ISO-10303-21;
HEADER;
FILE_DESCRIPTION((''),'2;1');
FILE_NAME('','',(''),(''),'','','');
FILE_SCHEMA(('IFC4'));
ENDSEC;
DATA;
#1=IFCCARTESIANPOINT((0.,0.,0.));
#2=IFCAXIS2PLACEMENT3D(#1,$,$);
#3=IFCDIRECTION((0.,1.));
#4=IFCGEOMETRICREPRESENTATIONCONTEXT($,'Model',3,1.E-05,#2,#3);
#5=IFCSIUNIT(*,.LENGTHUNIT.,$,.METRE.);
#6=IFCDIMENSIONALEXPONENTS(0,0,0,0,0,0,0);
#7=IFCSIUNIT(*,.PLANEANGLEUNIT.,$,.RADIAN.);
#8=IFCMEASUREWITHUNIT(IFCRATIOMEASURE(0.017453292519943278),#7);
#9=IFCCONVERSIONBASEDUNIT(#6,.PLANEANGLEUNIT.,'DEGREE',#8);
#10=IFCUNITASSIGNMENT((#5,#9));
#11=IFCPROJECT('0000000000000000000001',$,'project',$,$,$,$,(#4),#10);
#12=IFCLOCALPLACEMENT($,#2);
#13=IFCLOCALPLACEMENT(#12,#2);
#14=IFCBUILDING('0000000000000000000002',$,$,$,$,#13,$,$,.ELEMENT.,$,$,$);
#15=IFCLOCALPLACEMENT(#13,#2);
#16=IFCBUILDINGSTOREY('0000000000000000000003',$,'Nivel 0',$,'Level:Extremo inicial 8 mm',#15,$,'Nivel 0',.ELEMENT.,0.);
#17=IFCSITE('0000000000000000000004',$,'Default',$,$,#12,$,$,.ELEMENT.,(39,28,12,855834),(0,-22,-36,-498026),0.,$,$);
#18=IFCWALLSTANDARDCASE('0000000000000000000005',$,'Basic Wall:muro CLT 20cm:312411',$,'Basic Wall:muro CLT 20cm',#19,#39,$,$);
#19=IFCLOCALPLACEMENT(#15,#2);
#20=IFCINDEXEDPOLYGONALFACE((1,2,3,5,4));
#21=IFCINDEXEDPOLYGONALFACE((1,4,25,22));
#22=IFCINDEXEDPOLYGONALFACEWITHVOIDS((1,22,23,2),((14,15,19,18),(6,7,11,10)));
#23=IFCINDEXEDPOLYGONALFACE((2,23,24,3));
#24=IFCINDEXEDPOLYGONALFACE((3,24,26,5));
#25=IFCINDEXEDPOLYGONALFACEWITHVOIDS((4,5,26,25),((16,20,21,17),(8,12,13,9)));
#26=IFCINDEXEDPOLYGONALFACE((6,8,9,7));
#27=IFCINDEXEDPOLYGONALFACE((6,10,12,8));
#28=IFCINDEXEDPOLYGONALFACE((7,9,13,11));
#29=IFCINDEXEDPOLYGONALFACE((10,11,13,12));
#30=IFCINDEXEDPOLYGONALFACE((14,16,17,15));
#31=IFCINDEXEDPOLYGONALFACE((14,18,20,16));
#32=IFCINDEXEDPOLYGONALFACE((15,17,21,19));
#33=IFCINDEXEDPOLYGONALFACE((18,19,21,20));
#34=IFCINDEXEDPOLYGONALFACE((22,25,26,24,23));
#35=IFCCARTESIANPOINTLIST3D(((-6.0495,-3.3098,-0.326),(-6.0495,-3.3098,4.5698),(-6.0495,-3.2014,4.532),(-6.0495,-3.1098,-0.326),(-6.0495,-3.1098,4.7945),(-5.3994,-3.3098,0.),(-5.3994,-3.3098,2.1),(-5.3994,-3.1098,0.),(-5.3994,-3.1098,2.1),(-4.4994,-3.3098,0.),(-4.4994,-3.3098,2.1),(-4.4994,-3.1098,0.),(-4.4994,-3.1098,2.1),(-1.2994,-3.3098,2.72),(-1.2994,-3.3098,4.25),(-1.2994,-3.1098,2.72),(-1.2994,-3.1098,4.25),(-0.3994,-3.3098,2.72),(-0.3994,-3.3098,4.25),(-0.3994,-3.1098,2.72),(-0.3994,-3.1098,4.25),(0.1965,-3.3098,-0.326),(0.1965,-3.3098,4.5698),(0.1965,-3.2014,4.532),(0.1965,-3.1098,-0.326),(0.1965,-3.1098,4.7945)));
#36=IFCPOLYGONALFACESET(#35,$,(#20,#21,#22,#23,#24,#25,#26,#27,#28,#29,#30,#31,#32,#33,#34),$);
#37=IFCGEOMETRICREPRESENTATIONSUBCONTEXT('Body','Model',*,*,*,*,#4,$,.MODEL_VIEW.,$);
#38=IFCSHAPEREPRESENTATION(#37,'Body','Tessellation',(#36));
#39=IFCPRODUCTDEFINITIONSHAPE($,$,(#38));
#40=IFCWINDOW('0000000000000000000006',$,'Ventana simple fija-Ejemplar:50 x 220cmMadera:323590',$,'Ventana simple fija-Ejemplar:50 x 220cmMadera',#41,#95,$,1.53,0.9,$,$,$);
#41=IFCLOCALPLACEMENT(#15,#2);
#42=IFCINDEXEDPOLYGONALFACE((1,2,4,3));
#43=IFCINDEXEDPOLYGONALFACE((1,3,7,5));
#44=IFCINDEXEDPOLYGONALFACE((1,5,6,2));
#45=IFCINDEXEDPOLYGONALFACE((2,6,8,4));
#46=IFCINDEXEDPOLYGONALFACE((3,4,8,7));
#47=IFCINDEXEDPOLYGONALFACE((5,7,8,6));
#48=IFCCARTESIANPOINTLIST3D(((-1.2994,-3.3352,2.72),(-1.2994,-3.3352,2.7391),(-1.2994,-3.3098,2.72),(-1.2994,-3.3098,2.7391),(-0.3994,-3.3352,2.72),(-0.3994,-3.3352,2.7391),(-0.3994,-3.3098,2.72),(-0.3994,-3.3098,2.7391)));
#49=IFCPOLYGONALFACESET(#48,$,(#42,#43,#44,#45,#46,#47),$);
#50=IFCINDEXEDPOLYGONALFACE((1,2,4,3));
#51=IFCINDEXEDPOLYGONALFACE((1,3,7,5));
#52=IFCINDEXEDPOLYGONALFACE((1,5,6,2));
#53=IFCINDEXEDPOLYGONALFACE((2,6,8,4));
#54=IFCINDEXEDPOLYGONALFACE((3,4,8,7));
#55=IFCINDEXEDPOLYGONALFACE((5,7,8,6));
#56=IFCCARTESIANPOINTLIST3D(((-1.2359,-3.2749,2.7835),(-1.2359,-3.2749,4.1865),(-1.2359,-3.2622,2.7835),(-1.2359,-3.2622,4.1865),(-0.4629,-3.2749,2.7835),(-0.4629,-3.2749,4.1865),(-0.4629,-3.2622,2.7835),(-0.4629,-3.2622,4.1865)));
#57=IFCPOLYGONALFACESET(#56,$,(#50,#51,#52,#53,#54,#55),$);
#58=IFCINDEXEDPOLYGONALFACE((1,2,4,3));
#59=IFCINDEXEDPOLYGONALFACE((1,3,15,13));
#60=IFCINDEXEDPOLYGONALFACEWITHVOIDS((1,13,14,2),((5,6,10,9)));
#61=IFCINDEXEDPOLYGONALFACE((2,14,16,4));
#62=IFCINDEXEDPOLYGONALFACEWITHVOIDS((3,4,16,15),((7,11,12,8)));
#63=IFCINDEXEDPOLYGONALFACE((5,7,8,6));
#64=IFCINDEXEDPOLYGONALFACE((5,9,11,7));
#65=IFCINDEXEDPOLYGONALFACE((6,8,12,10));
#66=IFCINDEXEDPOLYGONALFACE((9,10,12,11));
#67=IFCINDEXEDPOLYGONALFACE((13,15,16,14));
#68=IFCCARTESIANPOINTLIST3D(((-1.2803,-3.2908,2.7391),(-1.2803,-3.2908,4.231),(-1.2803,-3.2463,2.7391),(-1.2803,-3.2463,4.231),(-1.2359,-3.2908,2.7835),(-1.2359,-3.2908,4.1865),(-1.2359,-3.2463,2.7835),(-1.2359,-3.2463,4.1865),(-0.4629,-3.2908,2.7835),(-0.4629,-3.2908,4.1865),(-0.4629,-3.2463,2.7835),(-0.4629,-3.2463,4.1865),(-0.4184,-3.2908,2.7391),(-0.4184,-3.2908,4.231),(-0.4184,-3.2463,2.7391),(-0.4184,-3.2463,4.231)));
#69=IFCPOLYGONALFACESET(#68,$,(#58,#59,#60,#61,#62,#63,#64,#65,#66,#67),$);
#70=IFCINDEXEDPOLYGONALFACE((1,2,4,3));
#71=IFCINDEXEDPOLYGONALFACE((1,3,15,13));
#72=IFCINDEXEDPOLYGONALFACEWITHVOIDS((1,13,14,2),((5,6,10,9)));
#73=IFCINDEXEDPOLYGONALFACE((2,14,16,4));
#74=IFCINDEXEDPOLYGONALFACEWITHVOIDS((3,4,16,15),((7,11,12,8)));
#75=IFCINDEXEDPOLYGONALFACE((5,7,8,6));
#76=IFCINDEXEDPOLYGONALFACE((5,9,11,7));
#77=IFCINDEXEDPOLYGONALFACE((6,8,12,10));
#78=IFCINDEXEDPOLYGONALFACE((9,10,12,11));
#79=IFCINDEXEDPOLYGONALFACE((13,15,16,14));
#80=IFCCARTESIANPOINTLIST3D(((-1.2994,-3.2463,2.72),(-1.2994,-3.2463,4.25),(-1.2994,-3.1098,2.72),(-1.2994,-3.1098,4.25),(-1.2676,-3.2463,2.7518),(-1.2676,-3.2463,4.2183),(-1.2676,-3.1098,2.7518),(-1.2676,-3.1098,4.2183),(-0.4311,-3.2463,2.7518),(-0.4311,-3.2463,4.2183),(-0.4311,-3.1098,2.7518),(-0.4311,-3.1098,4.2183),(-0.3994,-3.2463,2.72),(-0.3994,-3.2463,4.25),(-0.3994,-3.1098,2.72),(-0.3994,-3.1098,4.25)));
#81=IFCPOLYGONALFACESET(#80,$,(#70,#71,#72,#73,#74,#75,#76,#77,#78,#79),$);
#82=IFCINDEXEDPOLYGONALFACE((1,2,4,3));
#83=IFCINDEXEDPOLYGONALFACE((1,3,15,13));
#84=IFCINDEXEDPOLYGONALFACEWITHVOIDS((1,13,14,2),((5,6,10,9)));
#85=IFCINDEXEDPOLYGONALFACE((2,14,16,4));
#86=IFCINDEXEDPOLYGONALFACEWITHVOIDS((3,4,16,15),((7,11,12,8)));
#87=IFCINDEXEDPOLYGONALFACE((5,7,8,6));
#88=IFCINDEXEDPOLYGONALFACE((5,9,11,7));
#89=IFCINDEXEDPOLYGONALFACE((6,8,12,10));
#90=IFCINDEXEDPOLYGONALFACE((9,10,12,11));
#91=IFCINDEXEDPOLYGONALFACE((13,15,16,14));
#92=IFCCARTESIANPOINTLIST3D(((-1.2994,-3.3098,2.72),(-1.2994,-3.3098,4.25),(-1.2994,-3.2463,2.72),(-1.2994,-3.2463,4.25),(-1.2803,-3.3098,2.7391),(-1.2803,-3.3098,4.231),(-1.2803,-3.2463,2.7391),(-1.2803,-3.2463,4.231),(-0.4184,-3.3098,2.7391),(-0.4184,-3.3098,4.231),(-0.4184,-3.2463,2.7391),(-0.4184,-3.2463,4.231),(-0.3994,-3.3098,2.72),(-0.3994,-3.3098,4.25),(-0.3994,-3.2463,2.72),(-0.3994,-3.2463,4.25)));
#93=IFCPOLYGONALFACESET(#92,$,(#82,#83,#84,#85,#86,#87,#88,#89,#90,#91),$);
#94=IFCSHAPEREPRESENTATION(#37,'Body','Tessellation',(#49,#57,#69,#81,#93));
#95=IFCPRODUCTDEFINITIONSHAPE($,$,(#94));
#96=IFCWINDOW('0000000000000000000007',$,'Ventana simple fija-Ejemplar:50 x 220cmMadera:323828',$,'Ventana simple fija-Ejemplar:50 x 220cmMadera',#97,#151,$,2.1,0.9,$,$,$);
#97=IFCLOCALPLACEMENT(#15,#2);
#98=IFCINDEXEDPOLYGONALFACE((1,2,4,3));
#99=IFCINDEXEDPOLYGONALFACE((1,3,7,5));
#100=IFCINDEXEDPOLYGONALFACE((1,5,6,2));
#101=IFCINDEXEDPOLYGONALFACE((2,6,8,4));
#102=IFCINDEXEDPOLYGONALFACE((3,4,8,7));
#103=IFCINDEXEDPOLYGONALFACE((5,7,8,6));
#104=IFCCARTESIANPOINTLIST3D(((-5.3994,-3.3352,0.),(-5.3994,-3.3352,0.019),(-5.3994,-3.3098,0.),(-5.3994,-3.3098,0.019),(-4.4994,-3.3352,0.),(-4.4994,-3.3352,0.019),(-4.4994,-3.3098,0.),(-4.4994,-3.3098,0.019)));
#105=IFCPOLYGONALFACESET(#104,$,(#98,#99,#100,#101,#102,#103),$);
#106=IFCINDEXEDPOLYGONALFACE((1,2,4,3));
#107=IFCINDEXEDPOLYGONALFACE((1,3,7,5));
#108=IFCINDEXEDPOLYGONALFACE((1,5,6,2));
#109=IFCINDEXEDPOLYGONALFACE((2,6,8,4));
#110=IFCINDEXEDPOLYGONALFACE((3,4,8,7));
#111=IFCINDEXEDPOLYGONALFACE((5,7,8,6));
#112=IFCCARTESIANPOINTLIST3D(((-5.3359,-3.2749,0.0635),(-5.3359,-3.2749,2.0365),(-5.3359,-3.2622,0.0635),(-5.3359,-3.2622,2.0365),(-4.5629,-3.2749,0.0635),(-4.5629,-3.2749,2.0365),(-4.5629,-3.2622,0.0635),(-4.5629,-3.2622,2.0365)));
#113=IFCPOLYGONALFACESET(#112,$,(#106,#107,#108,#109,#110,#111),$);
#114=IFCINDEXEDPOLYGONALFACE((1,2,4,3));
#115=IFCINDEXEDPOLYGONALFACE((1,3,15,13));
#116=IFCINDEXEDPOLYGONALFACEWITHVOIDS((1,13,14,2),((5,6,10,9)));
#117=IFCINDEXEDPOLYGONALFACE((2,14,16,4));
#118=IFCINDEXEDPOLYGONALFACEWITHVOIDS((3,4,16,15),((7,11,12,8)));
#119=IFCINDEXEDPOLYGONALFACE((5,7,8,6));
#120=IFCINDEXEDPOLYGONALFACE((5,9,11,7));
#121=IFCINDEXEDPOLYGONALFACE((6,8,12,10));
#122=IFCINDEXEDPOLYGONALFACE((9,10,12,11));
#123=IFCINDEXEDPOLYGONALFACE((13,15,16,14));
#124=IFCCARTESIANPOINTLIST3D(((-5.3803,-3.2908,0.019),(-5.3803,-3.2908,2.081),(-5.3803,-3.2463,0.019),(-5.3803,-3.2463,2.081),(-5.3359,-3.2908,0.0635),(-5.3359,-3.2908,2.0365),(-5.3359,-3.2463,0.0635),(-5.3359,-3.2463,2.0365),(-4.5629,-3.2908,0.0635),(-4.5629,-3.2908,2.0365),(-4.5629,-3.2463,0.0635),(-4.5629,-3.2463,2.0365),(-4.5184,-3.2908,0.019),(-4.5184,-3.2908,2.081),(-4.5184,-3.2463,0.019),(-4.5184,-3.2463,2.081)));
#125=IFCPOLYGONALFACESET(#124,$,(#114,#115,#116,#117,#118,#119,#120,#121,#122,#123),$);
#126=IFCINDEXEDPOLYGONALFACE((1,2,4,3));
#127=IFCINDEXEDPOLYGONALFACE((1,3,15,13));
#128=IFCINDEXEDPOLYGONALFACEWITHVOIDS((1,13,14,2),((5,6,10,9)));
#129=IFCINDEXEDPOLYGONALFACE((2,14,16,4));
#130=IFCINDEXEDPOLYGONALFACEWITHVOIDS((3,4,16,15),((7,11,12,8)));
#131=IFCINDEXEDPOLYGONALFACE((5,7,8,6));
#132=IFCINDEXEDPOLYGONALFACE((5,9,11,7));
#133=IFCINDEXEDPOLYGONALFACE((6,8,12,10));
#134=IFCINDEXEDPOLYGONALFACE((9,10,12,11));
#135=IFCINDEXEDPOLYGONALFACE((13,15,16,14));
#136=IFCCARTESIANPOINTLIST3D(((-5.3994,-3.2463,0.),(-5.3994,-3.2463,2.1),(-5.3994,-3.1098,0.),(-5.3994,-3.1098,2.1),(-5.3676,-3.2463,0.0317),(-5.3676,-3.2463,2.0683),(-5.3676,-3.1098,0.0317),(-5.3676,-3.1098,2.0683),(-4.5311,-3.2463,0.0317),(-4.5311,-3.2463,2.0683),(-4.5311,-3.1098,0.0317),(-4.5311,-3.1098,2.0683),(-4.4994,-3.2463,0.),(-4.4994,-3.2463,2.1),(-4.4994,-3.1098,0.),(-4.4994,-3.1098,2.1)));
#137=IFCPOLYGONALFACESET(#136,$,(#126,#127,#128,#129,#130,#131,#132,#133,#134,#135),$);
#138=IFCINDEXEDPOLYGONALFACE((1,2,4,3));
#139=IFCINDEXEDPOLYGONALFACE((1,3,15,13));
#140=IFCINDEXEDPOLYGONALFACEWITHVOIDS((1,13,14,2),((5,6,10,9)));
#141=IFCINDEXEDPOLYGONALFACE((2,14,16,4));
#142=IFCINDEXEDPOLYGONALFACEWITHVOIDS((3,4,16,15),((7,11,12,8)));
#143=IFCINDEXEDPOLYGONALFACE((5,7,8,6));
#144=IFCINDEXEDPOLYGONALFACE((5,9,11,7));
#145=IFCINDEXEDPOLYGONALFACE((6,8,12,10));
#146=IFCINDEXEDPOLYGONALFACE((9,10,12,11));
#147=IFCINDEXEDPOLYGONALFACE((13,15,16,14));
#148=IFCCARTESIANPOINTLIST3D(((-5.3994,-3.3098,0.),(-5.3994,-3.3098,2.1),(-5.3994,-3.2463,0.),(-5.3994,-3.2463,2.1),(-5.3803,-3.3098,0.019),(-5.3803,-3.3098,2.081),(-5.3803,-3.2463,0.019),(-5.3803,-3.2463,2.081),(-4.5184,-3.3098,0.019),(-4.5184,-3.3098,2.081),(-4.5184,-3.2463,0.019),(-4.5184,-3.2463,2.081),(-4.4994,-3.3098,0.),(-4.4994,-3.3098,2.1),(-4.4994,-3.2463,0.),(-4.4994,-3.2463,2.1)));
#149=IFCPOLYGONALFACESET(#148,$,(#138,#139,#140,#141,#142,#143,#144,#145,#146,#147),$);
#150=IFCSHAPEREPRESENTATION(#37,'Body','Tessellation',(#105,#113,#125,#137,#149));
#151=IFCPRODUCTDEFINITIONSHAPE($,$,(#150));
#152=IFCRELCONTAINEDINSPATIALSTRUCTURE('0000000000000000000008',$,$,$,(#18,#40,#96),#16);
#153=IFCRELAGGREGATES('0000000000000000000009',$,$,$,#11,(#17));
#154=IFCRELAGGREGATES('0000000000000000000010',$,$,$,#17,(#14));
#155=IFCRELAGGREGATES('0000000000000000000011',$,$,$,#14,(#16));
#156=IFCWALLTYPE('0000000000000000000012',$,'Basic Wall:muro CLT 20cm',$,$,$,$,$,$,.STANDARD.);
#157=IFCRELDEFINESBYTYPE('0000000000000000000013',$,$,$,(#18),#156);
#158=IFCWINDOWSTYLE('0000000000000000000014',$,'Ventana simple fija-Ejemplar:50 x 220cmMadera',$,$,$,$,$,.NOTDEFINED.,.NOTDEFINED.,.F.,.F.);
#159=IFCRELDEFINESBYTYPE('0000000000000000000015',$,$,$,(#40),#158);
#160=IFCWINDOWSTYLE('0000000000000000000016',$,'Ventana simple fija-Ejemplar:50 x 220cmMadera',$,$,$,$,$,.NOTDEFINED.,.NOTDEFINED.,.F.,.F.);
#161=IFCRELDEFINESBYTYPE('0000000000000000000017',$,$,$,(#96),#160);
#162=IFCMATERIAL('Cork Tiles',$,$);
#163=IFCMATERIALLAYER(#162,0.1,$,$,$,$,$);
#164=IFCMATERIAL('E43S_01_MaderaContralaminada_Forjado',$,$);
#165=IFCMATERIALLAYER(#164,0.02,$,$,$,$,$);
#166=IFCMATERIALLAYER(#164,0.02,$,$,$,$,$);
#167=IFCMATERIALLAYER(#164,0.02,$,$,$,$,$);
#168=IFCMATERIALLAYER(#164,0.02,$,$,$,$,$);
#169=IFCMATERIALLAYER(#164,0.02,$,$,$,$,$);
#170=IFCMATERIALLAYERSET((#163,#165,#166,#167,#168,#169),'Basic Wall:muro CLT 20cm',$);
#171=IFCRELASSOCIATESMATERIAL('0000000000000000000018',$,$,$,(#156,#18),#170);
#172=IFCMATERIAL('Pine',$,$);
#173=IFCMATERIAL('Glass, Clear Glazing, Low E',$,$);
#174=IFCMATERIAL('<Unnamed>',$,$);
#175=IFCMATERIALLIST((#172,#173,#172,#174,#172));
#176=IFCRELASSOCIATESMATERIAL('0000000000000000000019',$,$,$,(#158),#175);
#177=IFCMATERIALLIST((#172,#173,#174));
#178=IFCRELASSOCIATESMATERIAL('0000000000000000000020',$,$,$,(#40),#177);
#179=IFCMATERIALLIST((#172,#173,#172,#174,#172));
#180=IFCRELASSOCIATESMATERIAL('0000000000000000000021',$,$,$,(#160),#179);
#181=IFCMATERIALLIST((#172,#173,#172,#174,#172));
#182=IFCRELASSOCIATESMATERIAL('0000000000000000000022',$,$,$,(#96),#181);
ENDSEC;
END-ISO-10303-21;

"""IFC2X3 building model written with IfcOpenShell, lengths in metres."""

from ifc_helpers import new_model, entity, si_unit, converted_unit, direction, frame, frame_2d, origin, origin_2d_with_axis, place, context, subcontext, project, spatial, polyline, rectangle, outline, extrude, clip, bounded_halfspace, source, transform, mapped, material, material_list, layer, layer_set, layer_usage, type_object, type_shapes, element, fill, save


model = new_model("IFC2X3")

# Units and contexts
model_context = context("Model", 3, precision=1e-05, world=origin(), true_north=direction((0.0, 1.0)))
body_context = subcontext(model_context, "Body", "Model", "MODEL_VIEW")
ifc_project = project(units=[si_unit("LENGTHUNIT", "METRE"), converted_unit("PLANEANGLEUNIT", "DEGREE", entity("IfcRatioMeasure", 0.017453292519943278), si_unit("PLANEANGLEUNIT", "RADIAN"), dimensions=[0, 0, 0, 0, 0, 0, 0])], contexts=[model_context])

# Site, building, storey
site_placement = place(None, origin())
site = spatial("IfcSite", under=ifc_project, at=site_placement, Name="Default", CompositionType="ELEMENT", RefLatitude=(39, 28, 12, 855834), RefLongitude=(0, -22, -36, -498026), RefElevation=0.0)
building_placement = place(site_placement, origin())
building = spatial("IfcBuilding", under=site, at=building_placement, CompositionType="ELEMENT")
storey_placement = place(building_placement, origin())
storey = spatial("IfcBuildingStorey", under=building, at=storey_placement, Name="Nivel 0", ObjectType="Level:Extremo inicial 8 mm", LongName="Nivel 0", CompositionType="ELEMENT", Elevation=0.0)

# Shared definitions
ifc_material_1 = material(Name="E43S_01_MaderaContralaminada_Forjado")
ifc_material_2 = material(Name="Cork Tiles")

# Wall, openings, windows
ifc_layer_1 = layer(ifc_material_2, 0.1)
ifc_layer_2 = layer(ifc_material_1, 0.02)
ifc_layer_3 = layer(ifc_material_1, 0.02)
ifc_layer_4 = layer(ifc_material_1, 0.02)
ifc_layer_5 = layer(ifc_material_1, 0.02)
ifc_layer_6 = layer(ifc_material_1, 0.02)
ifc_layer_set_1 = layer_set([ifc_layer_1, ifc_layer_2, ifc_layer_3, ifc_layer_4, ifc_layer_5, ifc_layer_6], Name="Basic Wall:muro CLT 20cm")
ifc_layer_usage_1 = layer_usage(ifc_layer_set_1, "AXIS2", "NEGATIVE", 0.1)
wall_type = type_object("IfcWallType", Name="Basic Wall:muro CLT 20cm", PredefinedType="STANDARD", material=ifc_layer_set_1)
wall_1_placement = place(storey_placement, frame((-6.0495, -3.2098, -0.326)))
wall_1 = element("IfcWallStandardCase", 1, at=wall_1_placement, inside=storey, type_object=wall_type, material=ifc_layer_usage_1, Name="Basic Wall:muro CLT 20cm:312411", ObjectType="Basic Wall:muro CLT 20cm", context=body_context, shape_type="Clipping", body=[
    clip(clip(extrude(rectangle(XDim=6.246, YDim=0.2, at=frame_2d((3.123, 0.0), x_axis=(-1.0, 0.0))), origin(), (0.0, 0.0, 1.0), 5.1205), bounded_halfspace(frame((0.0, -0.1, 4.8958), z_axis=(0.0, 0.329578, 0.944128), x_axis=(-1.0, 0.0, 0.0)), False, frame((0.0, -0.1, 4.8958)), polyline([(0.0, 0.0), (0.2, 0.0), (6.046, 0.0), (6.246, 0.0), (6.246, 0.1084), (0.0, 0.1084), (0.0, 0.0)]))), bounded_halfspace(frame((6.246, 0.0084, 4.858), z_axis=(0.0, -0.944128, 0.329578), x_axis=(-1.0, 0.0, 0.0)), False, frame((6.246, 0.0084, 4.858)), polyline([(0.0, 0.0), (0.0, 0.0916), (-6.246, 0.0916), (-6.246, 0.0), (0.0, 0.0)]))),
])
opening_1_placement = place(wall_1_placement, frame((5.6502, 0.1, 3.046)))
opening_1 = element("IfcOpeningElement", 2, at=opening_1_placement, cuts=wall_1, ObjectType="Opening", context=body_context, shape_type="SweptSolid", body=[
    extrude(rectangle(XDim=1.53, YDim=0.9, at=frame_2d((0.765, 0.45), x_axis=(-1.0, 0.0))), frame((0.0, 0.0, 0.0), z_axis=(0.0, -1.0, 0.0), x_axis=(0.0, 0.0, 1.0)), (0.0, 0.0, 1.0), 0.2),
])
opening_2_placement = place(wall_1_placement, frame((1.5502, 0.1, 0.326)))
opening_2 = element("IfcOpeningElement", 3, at=opening_2_placement, cuts=wall_1, ObjectType="Opening", context=body_context, shape_type="SweptSolid", body=[
    extrude(rectangle(XDim=2.1, YDim=0.9, at=frame_2d((1.05, 0.45), x_axis=(-1.0, 0.0))), frame((0.0, 0.0, 0.0), z_axis=(0.0, -1.0, 0.0), x_axis=(0.0, 0.0, 1.0)), (0.0, 0.0, 1.0), 0.2),
])
ifc_material_3 = material(Name="Pine")
ifc_material_4 = material(Name="Glass, Clear Glazing, Low E")
ifc_material_5 = material(Name="<Unnamed>")
ifc_material_list_1 = material_list([ifc_material_3, ifc_material_4, ifc_material_5])
ifc_material_list_2 = material_list([ifc_material_3, ifc_material_4, ifc_material_3, ifc_material_5, ifc_material_3])
window_style_1 = type_object("IfcWindowStyle", Name="Ventana simple fija-Ejemplar:50 x 220cmMadera", ConstructionType="NOTDEFINED", OperationType="NOTDEFINED", ParameterTakesPrecedence=False, Sizeable=False, material=ifc_material_list_2)
shared_shape_1 = source(origin(), body_context, "Body", "SweptSolid", [
    extrude(rectangle(XDim=0.9, YDim=0.0254, at=origin_2d_with_axis()), frame((0.5262, 0.2127, 0.0), z_axis=(0.0, 0.0, 1.0), x_axis=(-1.0, 0.0, 0.0)), (0.0, 0.0, 1.0), 0.019),
    extrude(rectangle(XDim=0.773, YDim=0.0127, at=frame_2d((0.0, 0.0), x_axis=(1.0, 0.0))), frame((0.5262, 0.1588, 0.0635)), (0.0, 0.0, 1.0), 1.403),
    extrude(outline(polyline([(-0.431, -0.7459), (0.431, -0.7459), (0.431, 0.7459), (-0.431, 0.7459), (-0.431, -0.7459)]), holes=[polyline([(-0.3865, -0.7015), (-0.3865, 0.7015), (0.3865, 0.7015), (0.3865, -0.7015), (-0.3865, -0.7015)])]), frame((0.5262, 0.181, 0.765), z_axis=(0.0, -1.0, 0.0), x_axis=(-1.0, 0.0, 0.0)), (0.0, 0.0, 1.0), 0.0444),
    extrude(outline(polyline([(-0.45, -0.765), (0.45, -0.765), (0.45, 0.765), (-0.45, 0.765), (-0.45, -0.765)]), holes=[polyline([(-0.4183, -0.7332), (-0.4183, 0.7332), (0.4183, 0.7332), (0.4183, -0.7332), (-0.4183, -0.7332)])]), frame((0.5262, 0.1365, 0.765), z_axis=(0.0, -1.0, 0.0), x_axis=(-1.0, 0.0, 0.0)), (0.0, 0.0, 1.0), 0.1365),
    extrude(outline(polyline([(-0.765, -0.45), (0.765, -0.45), (0.765, 0.45), (-0.765, 0.45), (-0.765, -0.45)]), holes=[polyline([(-0.7459, -0.431), (-0.7459, 0.431), (0.7459, 0.431), (0.7459, -0.431), (-0.7459, -0.431)])]), frame((0.5262, 0.2, 0.765), z_axis=(0.0, -1.0, 0.0), x_axis=(0.0, 0.0, -1.0)), (0.0, 0.0, 1.0), 0.0635),
])
type_shapes(window_style_1, [shared_shape_1])
window_1_placement = place(opening_1_placement, frame((0.0762, 0.0, 0.0), z_axis=(0.0, 0.0, 1.0), x_axis=(-1.0, 0.0, 0.0)))
window_1 = element("IfcWindow", 4, at=window_1_placement, inside=storey, type_object=window_style_1, material=ifc_material_list_1, Name="Ventana simple fija-Ejemplar:50 x 220cmMadera:323590", ObjectType="Ventana simple fija-Ejemplar:50 x 220cmMadera", OverallHeight=1.53, OverallWidth=0.9, context=body_context, shape_type="MappedRepresentation", body=[
    mapped(shared_shape_1, transform((0.0, 0.0, 0.0), scale=1.0)),
])
fill(opening_1, window_1)
ifc_material_list_3 = material_list([ifc_material_3, ifc_material_4, ifc_material_3, ifc_material_5, ifc_material_3])
ifc_material_list_4 = material_list([ifc_material_3, ifc_material_4, ifc_material_3, ifc_material_5, ifc_material_3])
window_style_2 = type_object("IfcWindowStyle", Name="Ventana simple fija-Ejemplar:50 x 220cmMadera", ConstructionType="NOTDEFINED", OperationType="NOTDEFINED", ParameterTakesPrecedence=False, Sizeable=False, material=ifc_material_list_4)
shared_shape_2 = source(origin(), body_context, "Body", "SweptSolid", [
    extrude(rectangle(XDim=0.9, YDim=0.0254, at=origin_2d_with_axis()), frame((0.5262, 0.2127, 0.0), z_axis=(0.0, 0.0, 1.0), x_axis=(-1.0, 0.0, 0.0)), (0.0, 0.0, 1.0), 0.019),
    extrude(rectangle(XDim=0.773, YDim=0.0127, at=frame_2d((0.0, 0.0), x_axis=(1.0, 0.0))), frame((0.5262, 0.1588, 0.0635)), (0.0, 0.0, 1.0), 1.973),
    extrude(outline(polyline([(-0.431, -1.031), (0.431, -1.031), (0.431, 1.031), (-0.431, 1.031), (-0.431, -1.031)]), holes=[polyline([(-0.3865, -0.9865), (-0.3865, 0.9865), (0.3865, 0.9865), (0.3865, -0.9865), (-0.3865, -0.9865)])]), frame((0.5262, 0.181, 1.05), z_axis=(0.0, -1.0, 0.0), x_axis=(-1.0, 0.0, 0.0)), (0.0, 0.0, 1.0), 0.0444),
    extrude(outline(polyline([(-0.45, -1.05), (0.45, -1.05), (0.45, 1.05), (-0.45, 1.05), (-0.45, -1.05)]), holes=[polyline([(-0.4183, -1.0183), (-0.4183, 1.0183), (0.4183, 1.0183), (0.4183, -1.0183), (-0.4183, -1.0183)])]), frame((0.5262, 0.1365, 1.05), z_axis=(0.0, -1.0, 0.0), x_axis=(-1.0, 0.0, 0.0)), (0.0, 0.0, 1.0), 0.1365),
    extrude(outline(polyline([(-1.05, -0.45), (1.05, -0.45), (1.05, 0.45), (-1.05, 0.45), (-1.05, -0.45)]), holes=[polyline([(-1.031, -0.431), (-1.031, 0.431), (1.031, 0.431), (1.031, -0.431), (-1.031, -0.431)])]), frame((0.5262, 0.2, 1.05), z_axis=(0.0, -1.0, 0.0), x_axis=(0.0, 0.0, -1.0)), (0.0, 0.0, 1.0), 0.0635),
])
type_shapes(window_style_2, [shared_shape_2])
window_2_placement = place(opening_2_placement, frame((0.0762, 0.0, 0.0), z_axis=(0.0, 0.0, 1.0), x_axis=(-1.0, 0.0, 0.0)))
window_2 = element("IfcWindow", 5, at=window_2_placement, inside=storey, type_object=window_style_2, material=ifc_material_list_3, Name="Ventana simple fija-Ejemplar:50 x 220cmMadera:323828", ObjectType="Ventana simple fija-Ejemplar:50 x 220cmMadera", OverallHeight=2.1, OverallWidth=0.9, context=body_context, shape_type="MappedRepresentation", body=[
    mapped(shared_shape_2, transform((0.0, 0.0, 0.0), scale=1.0)),
])
fill(opening_2, window_2)

save(model, "model.ifc")
